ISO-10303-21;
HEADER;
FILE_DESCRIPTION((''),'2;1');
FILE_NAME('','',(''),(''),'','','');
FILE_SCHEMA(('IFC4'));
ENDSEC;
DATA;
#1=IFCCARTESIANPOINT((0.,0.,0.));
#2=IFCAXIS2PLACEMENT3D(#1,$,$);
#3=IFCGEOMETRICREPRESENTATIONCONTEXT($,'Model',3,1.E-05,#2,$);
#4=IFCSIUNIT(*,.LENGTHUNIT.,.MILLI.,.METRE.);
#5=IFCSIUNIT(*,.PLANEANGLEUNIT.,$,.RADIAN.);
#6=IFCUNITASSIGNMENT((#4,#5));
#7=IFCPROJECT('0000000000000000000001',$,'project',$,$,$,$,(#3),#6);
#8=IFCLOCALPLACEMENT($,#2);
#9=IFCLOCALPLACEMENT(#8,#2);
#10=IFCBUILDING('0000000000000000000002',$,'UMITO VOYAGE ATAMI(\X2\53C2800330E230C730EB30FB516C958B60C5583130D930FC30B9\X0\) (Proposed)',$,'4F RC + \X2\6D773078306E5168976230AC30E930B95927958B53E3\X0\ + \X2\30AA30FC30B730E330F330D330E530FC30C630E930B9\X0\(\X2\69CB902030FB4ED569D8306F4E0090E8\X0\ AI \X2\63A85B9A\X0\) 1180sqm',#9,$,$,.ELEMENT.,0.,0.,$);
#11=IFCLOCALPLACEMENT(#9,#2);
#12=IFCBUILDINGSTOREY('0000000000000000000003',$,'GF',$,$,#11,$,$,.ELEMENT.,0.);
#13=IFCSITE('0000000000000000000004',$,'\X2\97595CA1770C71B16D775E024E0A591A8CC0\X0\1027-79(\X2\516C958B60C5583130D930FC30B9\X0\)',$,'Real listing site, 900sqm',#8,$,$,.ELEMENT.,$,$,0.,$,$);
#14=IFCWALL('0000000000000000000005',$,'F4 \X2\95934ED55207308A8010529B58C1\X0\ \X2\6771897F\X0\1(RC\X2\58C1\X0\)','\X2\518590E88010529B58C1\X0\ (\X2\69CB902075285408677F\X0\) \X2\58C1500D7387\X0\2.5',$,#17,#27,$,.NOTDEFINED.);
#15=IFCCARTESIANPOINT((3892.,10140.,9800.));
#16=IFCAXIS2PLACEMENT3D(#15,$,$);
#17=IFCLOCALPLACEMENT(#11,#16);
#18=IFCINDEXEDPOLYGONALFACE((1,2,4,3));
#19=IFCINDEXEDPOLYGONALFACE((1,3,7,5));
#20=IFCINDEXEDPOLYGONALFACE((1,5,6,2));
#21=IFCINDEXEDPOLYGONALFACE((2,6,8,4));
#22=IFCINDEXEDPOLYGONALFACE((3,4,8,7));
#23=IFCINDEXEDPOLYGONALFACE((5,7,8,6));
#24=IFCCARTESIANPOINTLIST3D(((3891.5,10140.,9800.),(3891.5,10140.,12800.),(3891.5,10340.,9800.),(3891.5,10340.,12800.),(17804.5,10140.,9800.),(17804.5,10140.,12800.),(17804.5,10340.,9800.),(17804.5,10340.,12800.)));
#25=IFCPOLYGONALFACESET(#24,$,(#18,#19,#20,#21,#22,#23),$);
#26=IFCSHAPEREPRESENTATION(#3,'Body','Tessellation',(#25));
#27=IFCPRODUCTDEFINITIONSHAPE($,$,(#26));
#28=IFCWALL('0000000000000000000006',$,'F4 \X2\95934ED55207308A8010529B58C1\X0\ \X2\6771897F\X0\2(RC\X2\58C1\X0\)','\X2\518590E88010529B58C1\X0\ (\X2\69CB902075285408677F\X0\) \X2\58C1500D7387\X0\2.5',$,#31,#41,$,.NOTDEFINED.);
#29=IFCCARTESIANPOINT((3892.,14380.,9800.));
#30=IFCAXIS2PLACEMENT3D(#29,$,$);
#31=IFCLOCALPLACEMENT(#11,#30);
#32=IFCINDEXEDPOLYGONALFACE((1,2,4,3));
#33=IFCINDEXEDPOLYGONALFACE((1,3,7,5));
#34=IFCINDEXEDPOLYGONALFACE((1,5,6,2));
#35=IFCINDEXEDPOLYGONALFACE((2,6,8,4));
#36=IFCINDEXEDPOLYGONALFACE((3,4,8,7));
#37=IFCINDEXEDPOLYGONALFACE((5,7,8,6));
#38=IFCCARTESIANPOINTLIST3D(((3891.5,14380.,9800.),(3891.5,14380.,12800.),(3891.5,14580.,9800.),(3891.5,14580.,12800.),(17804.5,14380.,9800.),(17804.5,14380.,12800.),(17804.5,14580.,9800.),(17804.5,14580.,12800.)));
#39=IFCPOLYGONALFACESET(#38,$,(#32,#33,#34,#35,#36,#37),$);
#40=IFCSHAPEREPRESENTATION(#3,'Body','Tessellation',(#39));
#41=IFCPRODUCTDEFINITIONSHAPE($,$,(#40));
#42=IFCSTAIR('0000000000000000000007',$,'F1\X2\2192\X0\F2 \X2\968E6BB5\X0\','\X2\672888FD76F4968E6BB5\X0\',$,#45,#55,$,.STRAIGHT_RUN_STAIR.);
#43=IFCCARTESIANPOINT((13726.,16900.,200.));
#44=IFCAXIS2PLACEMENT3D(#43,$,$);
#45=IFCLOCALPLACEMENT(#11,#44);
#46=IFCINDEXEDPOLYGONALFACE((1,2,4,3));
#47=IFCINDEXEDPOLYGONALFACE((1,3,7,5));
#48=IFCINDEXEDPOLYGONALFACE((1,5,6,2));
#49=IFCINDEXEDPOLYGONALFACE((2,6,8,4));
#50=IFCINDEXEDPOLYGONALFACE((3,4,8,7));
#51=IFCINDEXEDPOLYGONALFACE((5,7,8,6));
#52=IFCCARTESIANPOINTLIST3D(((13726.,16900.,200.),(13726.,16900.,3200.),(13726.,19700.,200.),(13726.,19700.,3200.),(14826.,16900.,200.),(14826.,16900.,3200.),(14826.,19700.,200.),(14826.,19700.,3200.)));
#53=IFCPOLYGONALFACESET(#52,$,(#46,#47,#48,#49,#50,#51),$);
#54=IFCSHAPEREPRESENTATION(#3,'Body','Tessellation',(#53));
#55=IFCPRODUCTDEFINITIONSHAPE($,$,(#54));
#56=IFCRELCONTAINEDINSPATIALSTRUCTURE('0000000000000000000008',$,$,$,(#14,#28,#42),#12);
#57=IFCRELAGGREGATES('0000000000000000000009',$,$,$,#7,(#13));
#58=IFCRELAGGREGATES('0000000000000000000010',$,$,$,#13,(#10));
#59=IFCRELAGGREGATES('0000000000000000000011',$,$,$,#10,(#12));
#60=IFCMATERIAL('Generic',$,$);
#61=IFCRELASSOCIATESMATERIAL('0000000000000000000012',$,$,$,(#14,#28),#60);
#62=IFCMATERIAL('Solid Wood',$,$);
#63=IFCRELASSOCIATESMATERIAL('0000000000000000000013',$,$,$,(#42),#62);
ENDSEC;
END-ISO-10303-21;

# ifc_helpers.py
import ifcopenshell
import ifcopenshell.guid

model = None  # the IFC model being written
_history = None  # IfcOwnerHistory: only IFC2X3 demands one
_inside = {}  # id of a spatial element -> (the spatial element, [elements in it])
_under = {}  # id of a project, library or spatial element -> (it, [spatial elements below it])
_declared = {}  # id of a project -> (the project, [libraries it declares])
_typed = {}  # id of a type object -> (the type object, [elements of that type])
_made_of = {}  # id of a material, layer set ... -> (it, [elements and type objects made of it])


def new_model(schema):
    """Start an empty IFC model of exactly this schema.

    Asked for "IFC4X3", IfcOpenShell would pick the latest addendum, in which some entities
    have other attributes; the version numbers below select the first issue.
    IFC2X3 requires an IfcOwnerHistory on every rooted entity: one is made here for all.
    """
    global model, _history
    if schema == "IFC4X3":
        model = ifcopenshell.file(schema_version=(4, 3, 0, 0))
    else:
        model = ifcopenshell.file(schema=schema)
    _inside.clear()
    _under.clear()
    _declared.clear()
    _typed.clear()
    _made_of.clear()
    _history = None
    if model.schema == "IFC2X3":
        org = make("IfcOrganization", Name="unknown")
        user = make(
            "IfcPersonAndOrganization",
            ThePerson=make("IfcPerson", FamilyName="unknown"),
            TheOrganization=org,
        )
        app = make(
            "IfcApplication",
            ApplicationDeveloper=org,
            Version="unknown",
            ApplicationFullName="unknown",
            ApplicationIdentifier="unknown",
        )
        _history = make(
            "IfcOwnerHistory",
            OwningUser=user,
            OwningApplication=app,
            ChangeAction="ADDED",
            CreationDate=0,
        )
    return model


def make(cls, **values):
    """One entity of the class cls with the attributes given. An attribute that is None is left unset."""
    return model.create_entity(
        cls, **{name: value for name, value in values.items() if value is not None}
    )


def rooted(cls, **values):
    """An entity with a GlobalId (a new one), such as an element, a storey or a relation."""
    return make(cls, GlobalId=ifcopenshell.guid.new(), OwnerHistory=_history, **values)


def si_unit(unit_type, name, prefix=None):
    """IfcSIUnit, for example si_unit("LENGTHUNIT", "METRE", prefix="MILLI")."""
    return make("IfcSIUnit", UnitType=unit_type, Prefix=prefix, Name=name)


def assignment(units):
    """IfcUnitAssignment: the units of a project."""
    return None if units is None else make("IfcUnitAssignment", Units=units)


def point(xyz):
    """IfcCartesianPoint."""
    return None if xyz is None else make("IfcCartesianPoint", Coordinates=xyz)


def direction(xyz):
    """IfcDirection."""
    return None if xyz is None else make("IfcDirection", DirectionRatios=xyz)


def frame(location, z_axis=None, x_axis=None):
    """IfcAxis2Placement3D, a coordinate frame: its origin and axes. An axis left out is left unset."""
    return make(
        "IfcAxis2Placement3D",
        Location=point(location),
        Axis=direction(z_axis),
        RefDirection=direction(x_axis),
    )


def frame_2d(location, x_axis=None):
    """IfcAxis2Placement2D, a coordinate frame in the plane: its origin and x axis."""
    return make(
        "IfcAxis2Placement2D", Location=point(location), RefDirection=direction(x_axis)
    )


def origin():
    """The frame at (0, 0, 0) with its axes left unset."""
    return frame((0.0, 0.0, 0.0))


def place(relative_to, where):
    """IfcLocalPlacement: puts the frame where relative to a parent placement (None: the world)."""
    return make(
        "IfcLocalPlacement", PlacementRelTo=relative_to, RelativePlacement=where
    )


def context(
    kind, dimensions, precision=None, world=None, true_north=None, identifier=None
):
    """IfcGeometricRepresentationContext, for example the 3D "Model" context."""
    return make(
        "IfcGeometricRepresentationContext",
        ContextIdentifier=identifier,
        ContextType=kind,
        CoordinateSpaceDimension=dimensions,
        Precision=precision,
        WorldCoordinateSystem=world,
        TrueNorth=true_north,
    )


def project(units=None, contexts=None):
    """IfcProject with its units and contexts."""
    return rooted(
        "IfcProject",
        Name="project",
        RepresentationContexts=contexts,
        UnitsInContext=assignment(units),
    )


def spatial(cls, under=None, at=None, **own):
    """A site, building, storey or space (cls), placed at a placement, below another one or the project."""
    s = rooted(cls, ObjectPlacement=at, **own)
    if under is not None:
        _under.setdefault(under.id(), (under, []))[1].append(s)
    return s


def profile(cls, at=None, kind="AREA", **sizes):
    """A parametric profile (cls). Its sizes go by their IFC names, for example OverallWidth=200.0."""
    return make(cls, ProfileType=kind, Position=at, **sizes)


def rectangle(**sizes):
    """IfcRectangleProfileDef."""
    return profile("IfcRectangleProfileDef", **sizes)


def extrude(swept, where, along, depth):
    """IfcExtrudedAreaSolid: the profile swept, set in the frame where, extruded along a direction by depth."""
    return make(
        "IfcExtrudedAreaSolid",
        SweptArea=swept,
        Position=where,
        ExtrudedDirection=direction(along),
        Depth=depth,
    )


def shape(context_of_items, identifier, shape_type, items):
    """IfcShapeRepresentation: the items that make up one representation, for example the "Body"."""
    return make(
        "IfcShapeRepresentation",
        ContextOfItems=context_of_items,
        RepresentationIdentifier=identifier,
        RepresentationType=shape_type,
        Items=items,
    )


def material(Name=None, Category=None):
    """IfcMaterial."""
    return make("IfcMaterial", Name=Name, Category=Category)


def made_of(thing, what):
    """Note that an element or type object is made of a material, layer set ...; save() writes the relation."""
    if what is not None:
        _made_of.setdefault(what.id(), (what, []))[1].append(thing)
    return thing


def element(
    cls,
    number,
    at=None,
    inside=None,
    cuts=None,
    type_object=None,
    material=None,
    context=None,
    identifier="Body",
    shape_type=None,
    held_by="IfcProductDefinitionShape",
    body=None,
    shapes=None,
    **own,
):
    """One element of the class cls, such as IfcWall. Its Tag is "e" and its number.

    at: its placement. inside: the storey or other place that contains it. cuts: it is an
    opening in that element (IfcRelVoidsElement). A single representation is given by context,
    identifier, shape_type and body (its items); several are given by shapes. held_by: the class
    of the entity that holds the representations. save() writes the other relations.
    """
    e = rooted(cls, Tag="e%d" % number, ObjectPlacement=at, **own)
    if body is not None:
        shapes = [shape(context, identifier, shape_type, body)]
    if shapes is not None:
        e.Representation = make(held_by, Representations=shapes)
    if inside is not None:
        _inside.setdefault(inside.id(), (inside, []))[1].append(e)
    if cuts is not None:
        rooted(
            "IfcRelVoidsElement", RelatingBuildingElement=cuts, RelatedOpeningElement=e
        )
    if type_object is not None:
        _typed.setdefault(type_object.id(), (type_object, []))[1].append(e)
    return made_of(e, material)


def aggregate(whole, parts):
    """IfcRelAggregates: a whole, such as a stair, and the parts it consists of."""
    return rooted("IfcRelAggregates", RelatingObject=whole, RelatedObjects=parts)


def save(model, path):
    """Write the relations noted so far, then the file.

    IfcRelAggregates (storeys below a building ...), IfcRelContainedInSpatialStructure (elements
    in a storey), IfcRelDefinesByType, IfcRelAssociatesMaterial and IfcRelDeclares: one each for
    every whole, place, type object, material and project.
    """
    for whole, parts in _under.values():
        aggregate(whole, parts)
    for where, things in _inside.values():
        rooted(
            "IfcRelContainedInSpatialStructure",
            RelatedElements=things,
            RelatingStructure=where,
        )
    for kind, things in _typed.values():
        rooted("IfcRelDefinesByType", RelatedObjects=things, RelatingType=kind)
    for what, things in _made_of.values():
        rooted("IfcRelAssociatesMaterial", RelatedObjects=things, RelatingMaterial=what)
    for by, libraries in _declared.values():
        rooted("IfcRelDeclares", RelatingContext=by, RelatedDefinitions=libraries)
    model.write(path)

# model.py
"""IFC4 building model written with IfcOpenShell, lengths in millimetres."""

from ifc_helpers import new_model, si_unit, frame, frame_2d, origin, place, context, project, spatial, rectangle, extrude, material, element, save


model = new_model("IFC4")

# Units and contexts
model_context = context("Model", 3, precision=1e-05, world=origin())
ifc_project = project(units=[si_unit("LENGTHUNIT", "METRE", prefix="MILLI"), si_unit("PLANEANGLEUNIT", "RADIAN")], contexts=[model_context])

# Site, building, storey
site_placement = place(None, origin())
site = spatial("IfcSite", under=ifc_project, at=site_placement, Name="静岡県熱海市上多賀1027-79(公開情報ベース)", ObjectType="Real listing site, 900sqm", CompositionType="ELEMENT", RefElevation=0.0)
building_placement = place(site_placement, origin())
building = spatial("IfcBuilding", under=site, at=building_placement, Name="UMITO VOYAGE ATAMI(参考モデル・公開情報ベース) (Proposed)", ObjectType="4F RC + 海への全面ガラス大開口 + オーシャンビューテラス(構造・仕様は一部 AI 推定) 1180sqm", CompositionType="ELEMENT", ElevationOfRefHeight=0.0, ElevationOfTerrain=0.0)
storey_placement = place(building_placement, origin())
storey = spatial("IfcBuildingStorey", under=building, at=storey_placement, Name="GF", CompositionType="ELEMENT", Elevation=0.0)

# Shared definitions
ifc_material_1 = material(Name="Generic")

# Walls
wall_1_placement = place(storey_placement, frame((3892.0, 10140.0, 9800.0)))
element("IfcWall", 1, at=wall_1_placement, inside=storey, material=ifc_material_1, Name="F4 間仕切り耐力壁 東西1(RC壁)", Description="内部耐力壁 (構造用合板) 壁倍率2.5", PredefinedType="NOTDEFINED", context=model_context, shape_type="SweptSolid", body=[
    extrude(rectangle(XDim=13913.0, YDim=200.0, at=frame_2d((6956.0, 100.0))), frame((3892.0, 10140.0, 9800.0)), (0.0, 0.0, 1.0), 3000.0),
])
wall_2_placement = place(storey_placement, frame((3892.0, 14380.0, 9800.0)))
element("IfcWall", 2, at=wall_2_placement, inside=storey, material=ifc_material_1, Name="F4 間仕切り耐力壁 東西2(RC壁)", Description="内部耐力壁 (構造用合板) 壁倍率2.5", PredefinedType="NOTDEFINED", context=model_context, shape_type="SweptSolid", body=[
    extrude(rectangle(XDim=13913.0, YDim=200.0, at=frame_2d((6956.0, 100.0))), frame((3892.0, 14380.0, 9800.0)), (0.0, 0.0, 1.0), 3000.0),
])

# Stair
ifc_material_2 = material(Name="Solid Wood")
stair_placement = place(storey_placement, frame((13726.0, 16900.0, 200.0)))
element("IfcStair", 3, at=stair_placement, inside=storey, material=ifc_material_2, Name="F1→F2 階段", Description="木製直階段", PredefinedType="STRAIGHT_RUN_STAIR", context=model_context, shape_type="SweptSolid", body=[
    extrude(rectangle(XDim=1100.0, YDim=2800.0, at=frame_2d((550.0, 1400.0))), frame((13726.0, 16900.0, 200.0)), (0.0, 0.0, 1.0), 3000.0),
])

save(model, "model.ifc")
